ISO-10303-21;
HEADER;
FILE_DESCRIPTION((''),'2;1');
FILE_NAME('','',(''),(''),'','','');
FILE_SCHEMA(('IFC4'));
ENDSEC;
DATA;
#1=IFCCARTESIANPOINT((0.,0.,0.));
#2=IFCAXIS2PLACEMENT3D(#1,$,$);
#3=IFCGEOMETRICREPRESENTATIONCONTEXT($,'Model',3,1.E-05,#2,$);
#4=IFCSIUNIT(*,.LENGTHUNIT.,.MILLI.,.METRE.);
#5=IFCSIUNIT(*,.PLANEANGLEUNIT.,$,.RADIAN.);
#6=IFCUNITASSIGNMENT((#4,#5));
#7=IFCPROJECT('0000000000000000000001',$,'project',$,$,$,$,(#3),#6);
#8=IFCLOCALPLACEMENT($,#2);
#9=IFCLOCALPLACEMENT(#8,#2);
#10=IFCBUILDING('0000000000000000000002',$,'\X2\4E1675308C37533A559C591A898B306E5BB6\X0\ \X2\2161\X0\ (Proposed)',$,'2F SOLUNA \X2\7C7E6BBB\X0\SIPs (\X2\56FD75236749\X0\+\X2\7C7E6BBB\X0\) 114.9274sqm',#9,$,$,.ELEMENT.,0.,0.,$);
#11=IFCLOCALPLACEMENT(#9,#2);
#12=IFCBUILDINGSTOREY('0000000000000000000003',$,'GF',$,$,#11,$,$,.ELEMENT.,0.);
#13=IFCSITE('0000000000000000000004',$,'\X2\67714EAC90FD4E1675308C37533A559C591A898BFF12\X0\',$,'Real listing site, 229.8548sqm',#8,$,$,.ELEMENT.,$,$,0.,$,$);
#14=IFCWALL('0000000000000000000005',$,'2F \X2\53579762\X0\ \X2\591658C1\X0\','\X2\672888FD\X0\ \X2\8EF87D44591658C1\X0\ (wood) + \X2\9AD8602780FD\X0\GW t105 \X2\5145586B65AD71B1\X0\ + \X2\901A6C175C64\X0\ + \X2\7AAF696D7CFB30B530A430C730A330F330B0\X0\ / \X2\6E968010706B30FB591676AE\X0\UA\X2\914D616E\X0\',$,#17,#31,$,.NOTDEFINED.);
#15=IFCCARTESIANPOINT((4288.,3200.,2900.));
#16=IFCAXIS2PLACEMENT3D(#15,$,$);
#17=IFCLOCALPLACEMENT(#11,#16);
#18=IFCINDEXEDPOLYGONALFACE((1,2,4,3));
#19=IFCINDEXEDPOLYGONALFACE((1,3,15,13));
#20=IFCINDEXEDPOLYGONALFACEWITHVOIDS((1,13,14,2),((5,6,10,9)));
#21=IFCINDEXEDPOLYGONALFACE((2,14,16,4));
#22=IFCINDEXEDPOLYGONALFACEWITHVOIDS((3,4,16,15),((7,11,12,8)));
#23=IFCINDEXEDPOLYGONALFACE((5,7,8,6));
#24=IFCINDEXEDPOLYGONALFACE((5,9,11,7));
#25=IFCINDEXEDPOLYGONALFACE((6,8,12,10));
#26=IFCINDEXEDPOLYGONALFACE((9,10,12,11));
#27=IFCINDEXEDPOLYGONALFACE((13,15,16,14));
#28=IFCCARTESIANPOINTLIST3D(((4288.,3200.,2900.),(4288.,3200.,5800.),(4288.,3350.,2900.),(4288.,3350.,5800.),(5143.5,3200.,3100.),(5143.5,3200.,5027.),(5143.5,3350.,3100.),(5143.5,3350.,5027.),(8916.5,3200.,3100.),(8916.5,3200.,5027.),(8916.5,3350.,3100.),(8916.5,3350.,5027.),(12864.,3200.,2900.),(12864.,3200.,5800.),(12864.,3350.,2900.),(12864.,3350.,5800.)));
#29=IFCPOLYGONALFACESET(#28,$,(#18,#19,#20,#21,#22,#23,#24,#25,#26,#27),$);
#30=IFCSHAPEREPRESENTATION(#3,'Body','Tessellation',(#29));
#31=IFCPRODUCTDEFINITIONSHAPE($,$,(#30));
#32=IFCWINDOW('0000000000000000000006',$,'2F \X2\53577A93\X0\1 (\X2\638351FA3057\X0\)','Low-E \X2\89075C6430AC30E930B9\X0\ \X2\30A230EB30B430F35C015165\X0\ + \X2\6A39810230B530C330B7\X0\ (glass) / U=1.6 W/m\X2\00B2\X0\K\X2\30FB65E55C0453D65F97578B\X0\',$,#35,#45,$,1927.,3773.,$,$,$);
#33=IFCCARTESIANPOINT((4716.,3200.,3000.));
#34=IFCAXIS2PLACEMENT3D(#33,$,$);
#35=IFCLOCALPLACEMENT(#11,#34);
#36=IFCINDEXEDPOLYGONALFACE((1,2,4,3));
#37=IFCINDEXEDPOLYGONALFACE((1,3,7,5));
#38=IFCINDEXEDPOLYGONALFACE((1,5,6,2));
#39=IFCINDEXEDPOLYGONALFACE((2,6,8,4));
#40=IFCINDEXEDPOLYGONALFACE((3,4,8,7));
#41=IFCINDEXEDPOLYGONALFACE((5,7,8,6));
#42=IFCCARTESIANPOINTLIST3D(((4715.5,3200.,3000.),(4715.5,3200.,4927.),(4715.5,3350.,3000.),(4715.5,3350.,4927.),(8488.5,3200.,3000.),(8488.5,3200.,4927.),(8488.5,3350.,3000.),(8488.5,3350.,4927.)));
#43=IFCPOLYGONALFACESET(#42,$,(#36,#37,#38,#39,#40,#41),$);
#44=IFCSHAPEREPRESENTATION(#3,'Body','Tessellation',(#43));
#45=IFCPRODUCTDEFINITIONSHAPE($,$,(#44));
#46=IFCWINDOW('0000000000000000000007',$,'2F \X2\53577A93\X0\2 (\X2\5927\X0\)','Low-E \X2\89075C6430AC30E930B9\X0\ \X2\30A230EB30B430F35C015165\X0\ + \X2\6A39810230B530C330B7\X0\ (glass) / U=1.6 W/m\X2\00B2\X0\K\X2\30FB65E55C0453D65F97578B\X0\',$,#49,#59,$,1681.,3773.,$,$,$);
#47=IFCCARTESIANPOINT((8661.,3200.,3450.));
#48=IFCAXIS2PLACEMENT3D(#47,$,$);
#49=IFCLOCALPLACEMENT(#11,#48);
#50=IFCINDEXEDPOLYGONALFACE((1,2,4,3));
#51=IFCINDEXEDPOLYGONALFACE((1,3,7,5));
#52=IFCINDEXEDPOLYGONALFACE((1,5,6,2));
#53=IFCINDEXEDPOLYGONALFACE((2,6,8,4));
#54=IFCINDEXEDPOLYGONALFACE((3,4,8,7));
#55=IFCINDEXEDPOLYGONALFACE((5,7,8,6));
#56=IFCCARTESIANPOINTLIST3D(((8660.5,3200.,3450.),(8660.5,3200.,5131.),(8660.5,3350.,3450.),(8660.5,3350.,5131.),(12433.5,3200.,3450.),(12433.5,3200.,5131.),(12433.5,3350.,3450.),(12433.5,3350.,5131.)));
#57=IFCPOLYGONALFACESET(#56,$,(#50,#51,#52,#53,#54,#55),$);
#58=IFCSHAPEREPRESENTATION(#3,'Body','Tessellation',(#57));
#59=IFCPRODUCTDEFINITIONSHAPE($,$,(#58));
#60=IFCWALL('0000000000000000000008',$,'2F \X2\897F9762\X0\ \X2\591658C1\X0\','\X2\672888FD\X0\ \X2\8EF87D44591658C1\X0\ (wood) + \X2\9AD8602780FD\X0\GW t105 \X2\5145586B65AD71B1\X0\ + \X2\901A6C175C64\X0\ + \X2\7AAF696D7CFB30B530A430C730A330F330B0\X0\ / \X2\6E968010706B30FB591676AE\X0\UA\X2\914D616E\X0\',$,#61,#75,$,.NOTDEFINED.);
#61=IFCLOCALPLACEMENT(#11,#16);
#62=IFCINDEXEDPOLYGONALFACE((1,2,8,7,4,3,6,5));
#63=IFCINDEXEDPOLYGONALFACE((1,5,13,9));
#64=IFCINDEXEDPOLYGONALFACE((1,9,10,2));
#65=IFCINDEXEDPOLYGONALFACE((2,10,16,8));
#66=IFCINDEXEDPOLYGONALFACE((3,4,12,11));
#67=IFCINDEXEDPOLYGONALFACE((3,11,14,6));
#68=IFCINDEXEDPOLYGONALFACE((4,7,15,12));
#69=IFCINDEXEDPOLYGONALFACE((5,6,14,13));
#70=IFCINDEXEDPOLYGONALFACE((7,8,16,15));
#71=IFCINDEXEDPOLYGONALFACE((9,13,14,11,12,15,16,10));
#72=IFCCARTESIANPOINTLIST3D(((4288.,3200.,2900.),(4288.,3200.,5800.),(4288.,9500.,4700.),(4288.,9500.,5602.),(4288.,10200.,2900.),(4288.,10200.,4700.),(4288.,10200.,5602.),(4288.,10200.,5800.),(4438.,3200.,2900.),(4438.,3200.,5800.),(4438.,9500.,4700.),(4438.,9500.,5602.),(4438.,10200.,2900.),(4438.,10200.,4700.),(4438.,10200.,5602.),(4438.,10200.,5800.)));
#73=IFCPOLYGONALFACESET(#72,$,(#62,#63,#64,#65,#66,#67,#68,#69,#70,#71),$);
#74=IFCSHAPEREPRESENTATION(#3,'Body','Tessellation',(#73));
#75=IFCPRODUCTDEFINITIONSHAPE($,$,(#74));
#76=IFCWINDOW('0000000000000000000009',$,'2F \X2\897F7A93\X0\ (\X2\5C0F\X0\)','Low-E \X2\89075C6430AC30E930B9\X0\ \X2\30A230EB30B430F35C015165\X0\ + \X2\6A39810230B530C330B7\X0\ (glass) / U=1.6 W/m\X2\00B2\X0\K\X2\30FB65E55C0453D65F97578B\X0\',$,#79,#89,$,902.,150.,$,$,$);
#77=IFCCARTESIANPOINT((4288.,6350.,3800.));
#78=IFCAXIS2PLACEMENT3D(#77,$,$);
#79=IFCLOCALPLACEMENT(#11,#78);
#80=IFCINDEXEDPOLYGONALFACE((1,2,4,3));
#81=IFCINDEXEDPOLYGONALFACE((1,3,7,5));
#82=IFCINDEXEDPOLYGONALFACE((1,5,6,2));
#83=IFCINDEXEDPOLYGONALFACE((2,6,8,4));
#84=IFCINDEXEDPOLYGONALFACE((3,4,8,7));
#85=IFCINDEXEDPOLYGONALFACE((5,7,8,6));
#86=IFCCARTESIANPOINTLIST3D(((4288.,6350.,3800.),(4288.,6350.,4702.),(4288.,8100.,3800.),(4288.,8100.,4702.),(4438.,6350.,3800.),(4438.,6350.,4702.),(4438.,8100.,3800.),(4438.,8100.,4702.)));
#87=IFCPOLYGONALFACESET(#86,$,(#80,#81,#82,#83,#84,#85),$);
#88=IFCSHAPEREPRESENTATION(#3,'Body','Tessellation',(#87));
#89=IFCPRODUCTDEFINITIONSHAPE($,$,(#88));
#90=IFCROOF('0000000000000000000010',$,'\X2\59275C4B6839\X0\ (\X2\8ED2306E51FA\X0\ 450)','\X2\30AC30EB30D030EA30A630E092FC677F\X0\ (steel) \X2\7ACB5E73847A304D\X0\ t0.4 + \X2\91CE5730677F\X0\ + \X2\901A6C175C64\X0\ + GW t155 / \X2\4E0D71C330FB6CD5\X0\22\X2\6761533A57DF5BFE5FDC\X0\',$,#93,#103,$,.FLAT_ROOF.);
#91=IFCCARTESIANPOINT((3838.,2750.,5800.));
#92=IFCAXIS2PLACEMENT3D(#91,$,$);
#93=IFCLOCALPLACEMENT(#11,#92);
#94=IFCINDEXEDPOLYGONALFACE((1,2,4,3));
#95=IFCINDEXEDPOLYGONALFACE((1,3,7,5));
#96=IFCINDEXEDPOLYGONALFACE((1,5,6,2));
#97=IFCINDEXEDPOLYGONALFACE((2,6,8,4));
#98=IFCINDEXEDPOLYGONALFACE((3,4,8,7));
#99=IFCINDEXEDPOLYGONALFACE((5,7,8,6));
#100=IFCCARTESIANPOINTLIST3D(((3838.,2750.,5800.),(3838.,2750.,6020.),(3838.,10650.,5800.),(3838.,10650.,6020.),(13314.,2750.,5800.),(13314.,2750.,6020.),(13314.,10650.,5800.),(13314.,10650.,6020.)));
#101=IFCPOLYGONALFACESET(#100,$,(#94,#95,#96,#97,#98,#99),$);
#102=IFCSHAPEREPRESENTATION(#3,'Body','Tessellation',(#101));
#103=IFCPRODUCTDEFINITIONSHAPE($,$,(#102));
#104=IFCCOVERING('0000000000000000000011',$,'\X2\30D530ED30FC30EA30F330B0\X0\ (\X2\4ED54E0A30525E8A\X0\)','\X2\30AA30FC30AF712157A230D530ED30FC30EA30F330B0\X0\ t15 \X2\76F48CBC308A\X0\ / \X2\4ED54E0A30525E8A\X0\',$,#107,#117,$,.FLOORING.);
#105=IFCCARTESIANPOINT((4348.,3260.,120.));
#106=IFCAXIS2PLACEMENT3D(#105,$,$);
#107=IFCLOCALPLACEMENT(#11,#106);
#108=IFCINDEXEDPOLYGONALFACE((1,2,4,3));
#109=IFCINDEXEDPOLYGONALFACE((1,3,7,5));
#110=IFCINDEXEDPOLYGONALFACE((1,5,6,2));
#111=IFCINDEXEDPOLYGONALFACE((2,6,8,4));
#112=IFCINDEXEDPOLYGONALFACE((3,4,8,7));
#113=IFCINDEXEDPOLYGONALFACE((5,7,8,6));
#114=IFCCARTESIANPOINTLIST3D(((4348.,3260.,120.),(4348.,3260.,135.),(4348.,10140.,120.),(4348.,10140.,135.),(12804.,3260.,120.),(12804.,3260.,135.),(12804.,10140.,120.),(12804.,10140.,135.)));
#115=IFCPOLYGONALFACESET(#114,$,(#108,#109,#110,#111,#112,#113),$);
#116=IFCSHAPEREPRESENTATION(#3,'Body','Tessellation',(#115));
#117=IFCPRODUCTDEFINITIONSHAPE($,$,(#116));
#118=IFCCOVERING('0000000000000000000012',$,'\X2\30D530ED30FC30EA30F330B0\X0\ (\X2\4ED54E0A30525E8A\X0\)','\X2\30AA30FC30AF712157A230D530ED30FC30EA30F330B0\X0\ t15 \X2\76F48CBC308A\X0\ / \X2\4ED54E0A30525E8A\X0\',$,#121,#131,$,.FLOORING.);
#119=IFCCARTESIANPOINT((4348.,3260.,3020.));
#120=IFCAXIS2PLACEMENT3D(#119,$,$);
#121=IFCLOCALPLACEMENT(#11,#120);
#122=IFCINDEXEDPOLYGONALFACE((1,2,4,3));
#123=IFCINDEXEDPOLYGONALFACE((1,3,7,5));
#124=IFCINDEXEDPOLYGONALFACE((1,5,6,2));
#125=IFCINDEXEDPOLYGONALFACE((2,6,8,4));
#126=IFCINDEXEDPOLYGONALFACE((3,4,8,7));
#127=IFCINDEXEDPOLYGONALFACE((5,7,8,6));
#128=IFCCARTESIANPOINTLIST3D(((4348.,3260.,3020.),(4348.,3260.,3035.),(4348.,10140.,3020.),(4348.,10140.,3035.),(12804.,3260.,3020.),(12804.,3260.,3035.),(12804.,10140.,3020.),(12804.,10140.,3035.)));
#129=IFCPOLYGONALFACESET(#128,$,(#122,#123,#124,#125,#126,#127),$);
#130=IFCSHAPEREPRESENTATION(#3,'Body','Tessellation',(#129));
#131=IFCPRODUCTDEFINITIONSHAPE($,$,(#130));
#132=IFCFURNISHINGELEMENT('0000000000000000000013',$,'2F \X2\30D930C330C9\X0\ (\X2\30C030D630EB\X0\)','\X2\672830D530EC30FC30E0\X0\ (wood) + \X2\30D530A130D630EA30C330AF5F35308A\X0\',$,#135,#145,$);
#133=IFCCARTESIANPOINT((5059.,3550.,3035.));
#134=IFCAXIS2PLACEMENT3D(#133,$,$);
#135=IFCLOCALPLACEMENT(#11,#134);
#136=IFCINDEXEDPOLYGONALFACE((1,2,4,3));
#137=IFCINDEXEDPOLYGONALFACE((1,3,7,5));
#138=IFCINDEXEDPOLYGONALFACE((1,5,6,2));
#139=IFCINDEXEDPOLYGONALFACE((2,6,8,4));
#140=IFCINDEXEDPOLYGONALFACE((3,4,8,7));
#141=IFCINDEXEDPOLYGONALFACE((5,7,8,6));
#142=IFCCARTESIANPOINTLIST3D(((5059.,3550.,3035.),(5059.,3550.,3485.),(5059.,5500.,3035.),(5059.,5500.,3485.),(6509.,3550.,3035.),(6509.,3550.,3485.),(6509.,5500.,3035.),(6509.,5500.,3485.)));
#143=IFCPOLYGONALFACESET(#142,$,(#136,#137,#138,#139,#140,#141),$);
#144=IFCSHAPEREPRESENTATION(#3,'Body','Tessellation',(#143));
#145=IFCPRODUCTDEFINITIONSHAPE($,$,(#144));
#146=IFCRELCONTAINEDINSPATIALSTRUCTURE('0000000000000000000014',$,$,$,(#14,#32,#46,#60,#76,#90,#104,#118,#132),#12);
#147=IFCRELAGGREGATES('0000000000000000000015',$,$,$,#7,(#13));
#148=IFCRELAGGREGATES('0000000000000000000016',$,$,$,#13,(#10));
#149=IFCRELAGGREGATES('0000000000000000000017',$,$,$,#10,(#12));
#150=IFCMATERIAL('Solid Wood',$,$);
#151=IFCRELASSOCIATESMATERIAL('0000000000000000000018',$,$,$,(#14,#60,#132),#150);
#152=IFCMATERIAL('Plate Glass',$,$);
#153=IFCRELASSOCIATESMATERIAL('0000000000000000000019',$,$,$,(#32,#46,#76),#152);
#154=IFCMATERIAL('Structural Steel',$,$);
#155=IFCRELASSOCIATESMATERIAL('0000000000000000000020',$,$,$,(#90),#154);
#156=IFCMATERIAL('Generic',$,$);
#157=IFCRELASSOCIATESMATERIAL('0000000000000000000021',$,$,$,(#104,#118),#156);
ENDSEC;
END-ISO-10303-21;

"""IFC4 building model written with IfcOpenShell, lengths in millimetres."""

from ifc_helpers import new_model, si_unit, frame, frame_2d, origin, place, context, project, spatial, rectangle, extrude, material, element, fill, save


model = new_model("IFC4")

# Units and contexts
model_context = context("Model", 3, precision=1e-05, world=origin())
ifc_project = project(units=[si_unit("LENGTHUNIT", "METRE", prefix="MILLI"), si_unit("PLANEANGLEUNIT", "RADIAN")], contexts=[model_context])

# Site, building, storey
site_placement = place(None, origin())
site = spatial("IfcSite", under=ifc_project, at=site_placement, Name="東京都世田谷区喜多見２", ObjectType="Real listing site, 229.8548sqm", CompositionType="ELEMENT", RefElevation=0.0)
building_placement = place(site_placement, origin())
building = spatial("IfcBuilding", under=site, at=building_placement, Name="世田谷区喜多見の家 Ⅱ (Proposed)", ObjectType="2F SOLUNA 籾殻SIPs (国産杉+籾殻) 114.9274sqm", CompositionType="ELEMENT", ElevationOfRefHeight=0.0, ElevationOfTerrain=0.0)
storey_placement = place(building_placement, origin())
storey = spatial("IfcBuildingStorey", under=building, at=storey_placement, Name="GF", CompositionType="ELEMENT", Elevation=0.0)

# Shared definitions
ifc_material_1 = material(Name="Solid Wood")

# Shared definitions
ifc_material_2 = material(Name="Plate Glass")

# Wall, openings, windows
wall_1_placement = place(storey_placement, frame((4288.0, 3200.0, 2900.0)))
wall_1 = element("IfcWall", 1, at=wall_1_placement, inside=storey, material=ifc_material_1, Name="2F 南面 外壁", Description="木製 軸組外壁 (wood) + 高性能GW t105 充填断熱 + 通気層 + 窯業系サイディング / 準耐火・外皮UA配慮", PredefinedType="NOTDEFINED", context=model_context, shape_type="SweptSolid", body=[
    extrude(rectangle(XDim=8576.0, YDim=150.0, at=frame_2d((4288.0, 75.0))), frame((4288.0, 3200.0, 2900.0)), (0.0, 0.0, 1.0), 2900.0),
])
opening_1_placement = place(storey_placement, frame((4716.0, 3200.0, 3000.0)))
opening_1 = element("IfcOpeningElement", 2, at=opening_1_placement, cuts=wall_1, PredefinedType="NOTDEFINED", context=model_context, shape_type="SweptSolid", body=[
    extrude(rectangle(XDim=3773.0, YDim=150.0, at=frame_2d((1886.0, 75.0))), frame((4716.0, 3200.0, 3000.0)), (0.0, 0.0, 1.0), 1927.0),
])
opening_2_placement = place(storey_placement, frame((8661.0, 3200.0, 3450.0)))
opening_2 = element("IfcOpeningElement", 3, at=opening_2_placement, cuts=wall_1, PredefinedType="NOTDEFINED", context=model_context, shape_type="SweptSolid", body=[
    extrude(rectangle(XDim=3773.0, YDim=150.0, at=frame_2d((1886.0, 75.0))), frame((8661.0, 3200.0, 3450.0)), (0.0, 0.0, 1.0), 1681.0),
])
window_1_placement = place(storey_placement, frame((4716.0, 3200.0, 3000.0)))
window_1 = element("IfcWindow", 4, at=window_1_placement, inside=storey, material=ifc_material_2, Name="2F 南窓1 (掃出し)", Description="Low-E 複層ガラス アルゴン封入 + 樹脂サッシ (glass) / U=1.6 W/m²K・日射取得型", OverallHeight=1927.0, OverallWidth=3773.0, context=model_context, shape_type="SweptSolid", body=[
    extrude(rectangle(XDim=3773.0, YDim=150.0, at=frame_2d((1886.0, 75.0))), frame((4716.0, 3200.0, 3000.0)), (0.0, 0.0, 1.0), 1927.0),
])
fill(opening_1, window_1)
window_2_placement = place(storey_placement, frame((8661.0, 3200.0, 3450.0)))
window_2 = element("IfcWindow", 5, at=window_2_placement, inside=storey, material=ifc_material_2, Name="2F 南窓2 (大)", Description="Low-E 複層ガラス アルゴン封入 + 樹脂サッシ (glass) / U=1.6 W/m²K・日射取得型", OverallHeight=1681.0, OverallWidth=3773.0, context=model_context, shape_type="SweptSolid", body=[
    extrude(rectangle(XDim=3773.0, YDim=150.0, at=frame_2d((1886.0, 75.0))), frame((8661.0, 3200.0, 3450.0)), (0.0, 0.0, 1.0), 1681.0),
])
fill(opening_2, window_2)

# Wall, opening, window
wall_2_placement = place(storey_placement, frame((4288.0, 3200.0, 2900.0)))
wall_2 = element("IfcWall", 6, at=wall_2_placement, inside=storey, material=ifc_material_1, Name="2F 西面 外壁", Description="木製 軸組外壁 (wood) + 高性能GW t105 充填断熱 + 通気層 + 窯業系サイディング / 準耐火・外皮UA配慮", PredefinedType="NOTDEFINED", context=model_context, shape_type="SweptSolid", body=[
    extrude(rectangle(XDim=150.0, YDim=7000.0, at=frame_2d((75.0, 3500.0))), frame((4288.0, 3200.0, 2900.0)), (0.0, 0.0, 1.0), 2900.0),
])
opening_3_placement = place(storey_placement, frame((4288.0, 6350.0, 3800.0)))
opening_3 = element("IfcOpeningElement", 7, at=opening_3_placement, cuts=wall_2, PredefinedType="NOTDEFINED", context=model_context, shape_type="SweptSolid", body=[
    extrude(rectangle(XDim=150.0, YDim=1750.0, at=frame_2d((75.0, 875.0))), frame((4288.0, 6350.0, 3800.0)), (0.0, 0.0, 1.0), 902.0),
])
window_3_placement = place(storey_placement, frame((4288.0, 6350.0, 3800.0)))
window_3 = element("IfcWindow", 8, at=window_3_placement, inside=storey, material=ifc_material_2, Name="2F 西窓 (小)", Description="Low-E 複層ガラス アルゴン封入 + 樹脂サッシ (glass) / U=1.6 W/m²K・日射取得型", OverallHeight=902.0, OverallWidth=150.0, context=model_context, shape_type="SweptSolid", body=[
    extrude(rectangle(XDim=150.0, YDim=1750.0, at=frame_2d((75.0, 875.0))), frame((4288.0, 6350.0, 3800.0)), (0.0, 0.0, 1.0), 902.0),
])
fill(opening_3, window_3)

# Roof
ifc_material_3 = material(Name="Structural Steel")
roof_placement = place(storey_placement, frame((3838.0, 2750.0, 5800.0)))
element("IfcRoof", 9, at=roof_placement, inside=storey, material=ifc_material_3, Name="大屋根 (軒の出 450)", Description="ガルバリウム鋼板 (steel) 立平葺き t0.4 + 野地板 + 通気層 + GW t155 / 不燃・法22条区域対応", PredefinedType="FLAT_ROOF", context=model_context, shape_type="SweptSolid", body=[
    extrude(rectangle(XDim=9476.0, YDim=7900.0, at=frame_2d((4738.0, 3950.0))), frame((3838.0, 2750.0, 5800.0)), (0.0, 0.0, 1.0), 220.0),
])

# Coverings
ifc_material_4 = material(Name="Generic")
covering_1_placement = place(storey_placement, frame((4348.0, 3260.0, 120.0)))
element("IfcCovering", 10, at=covering_1_placement, inside=storey, material=ifc_material_4, Name="フローリング (仕上げ床)", Description="オーク無垢フローリング t15 直貼り / 仕上げ床", PredefinedType="FLOORING", context=model_context, shape_type="SweptSolid", body=[
    extrude(rectangle(XDim=8456.0, YDim=6880.0, at=frame_2d((4228.0, 3440.0))), frame((4348.0, 3260.0, 120.0)), (0.0, 0.0, 1.0), 15.0),
])
covering_2_placement = place(storey_placement, frame((4348.0, 3260.0, 3020.0)))
element("IfcCovering", 11, at=covering_2_placement, inside=storey, material=ifc_material_4, Name="フローリング (仕上げ床)", Description="オーク無垢フローリング t15 直貼り / 仕上げ床", PredefinedType="FLOORING", context=model_context, shape_type="SweptSolid", body=[
    extrude(rectangle(XDim=8456.0, YDim=6880.0, at=frame_2d((4228.0, 3440.0))), frame((4348.0, 3260.0, 3020.0)), (0.0, 0.0, 1.0), 15.0),
])

# Furnishing element
furnishing_placement = place(storey_placement, frame((5059.0, 3550.0, 3035.0)))
element("IfcFurnishingElement", 12, at=furnishing_placement, inside=storey, material=ifc_material_1, Name="2F ベッド (ダブル)", Description="木フレーム (wood) + ファブリック張り", context=model_context, shape_type="SweptSolid", body=[
    extrude(rectangle(XDim=1450.0, YDim=1950.0, at=frame_2d((725.0, 975.0))), frame((5059.0, 3550.0, 3035.0)), (0.0, 0.0, 1.0), 450.0),
])

save(model, "model.ifc")
